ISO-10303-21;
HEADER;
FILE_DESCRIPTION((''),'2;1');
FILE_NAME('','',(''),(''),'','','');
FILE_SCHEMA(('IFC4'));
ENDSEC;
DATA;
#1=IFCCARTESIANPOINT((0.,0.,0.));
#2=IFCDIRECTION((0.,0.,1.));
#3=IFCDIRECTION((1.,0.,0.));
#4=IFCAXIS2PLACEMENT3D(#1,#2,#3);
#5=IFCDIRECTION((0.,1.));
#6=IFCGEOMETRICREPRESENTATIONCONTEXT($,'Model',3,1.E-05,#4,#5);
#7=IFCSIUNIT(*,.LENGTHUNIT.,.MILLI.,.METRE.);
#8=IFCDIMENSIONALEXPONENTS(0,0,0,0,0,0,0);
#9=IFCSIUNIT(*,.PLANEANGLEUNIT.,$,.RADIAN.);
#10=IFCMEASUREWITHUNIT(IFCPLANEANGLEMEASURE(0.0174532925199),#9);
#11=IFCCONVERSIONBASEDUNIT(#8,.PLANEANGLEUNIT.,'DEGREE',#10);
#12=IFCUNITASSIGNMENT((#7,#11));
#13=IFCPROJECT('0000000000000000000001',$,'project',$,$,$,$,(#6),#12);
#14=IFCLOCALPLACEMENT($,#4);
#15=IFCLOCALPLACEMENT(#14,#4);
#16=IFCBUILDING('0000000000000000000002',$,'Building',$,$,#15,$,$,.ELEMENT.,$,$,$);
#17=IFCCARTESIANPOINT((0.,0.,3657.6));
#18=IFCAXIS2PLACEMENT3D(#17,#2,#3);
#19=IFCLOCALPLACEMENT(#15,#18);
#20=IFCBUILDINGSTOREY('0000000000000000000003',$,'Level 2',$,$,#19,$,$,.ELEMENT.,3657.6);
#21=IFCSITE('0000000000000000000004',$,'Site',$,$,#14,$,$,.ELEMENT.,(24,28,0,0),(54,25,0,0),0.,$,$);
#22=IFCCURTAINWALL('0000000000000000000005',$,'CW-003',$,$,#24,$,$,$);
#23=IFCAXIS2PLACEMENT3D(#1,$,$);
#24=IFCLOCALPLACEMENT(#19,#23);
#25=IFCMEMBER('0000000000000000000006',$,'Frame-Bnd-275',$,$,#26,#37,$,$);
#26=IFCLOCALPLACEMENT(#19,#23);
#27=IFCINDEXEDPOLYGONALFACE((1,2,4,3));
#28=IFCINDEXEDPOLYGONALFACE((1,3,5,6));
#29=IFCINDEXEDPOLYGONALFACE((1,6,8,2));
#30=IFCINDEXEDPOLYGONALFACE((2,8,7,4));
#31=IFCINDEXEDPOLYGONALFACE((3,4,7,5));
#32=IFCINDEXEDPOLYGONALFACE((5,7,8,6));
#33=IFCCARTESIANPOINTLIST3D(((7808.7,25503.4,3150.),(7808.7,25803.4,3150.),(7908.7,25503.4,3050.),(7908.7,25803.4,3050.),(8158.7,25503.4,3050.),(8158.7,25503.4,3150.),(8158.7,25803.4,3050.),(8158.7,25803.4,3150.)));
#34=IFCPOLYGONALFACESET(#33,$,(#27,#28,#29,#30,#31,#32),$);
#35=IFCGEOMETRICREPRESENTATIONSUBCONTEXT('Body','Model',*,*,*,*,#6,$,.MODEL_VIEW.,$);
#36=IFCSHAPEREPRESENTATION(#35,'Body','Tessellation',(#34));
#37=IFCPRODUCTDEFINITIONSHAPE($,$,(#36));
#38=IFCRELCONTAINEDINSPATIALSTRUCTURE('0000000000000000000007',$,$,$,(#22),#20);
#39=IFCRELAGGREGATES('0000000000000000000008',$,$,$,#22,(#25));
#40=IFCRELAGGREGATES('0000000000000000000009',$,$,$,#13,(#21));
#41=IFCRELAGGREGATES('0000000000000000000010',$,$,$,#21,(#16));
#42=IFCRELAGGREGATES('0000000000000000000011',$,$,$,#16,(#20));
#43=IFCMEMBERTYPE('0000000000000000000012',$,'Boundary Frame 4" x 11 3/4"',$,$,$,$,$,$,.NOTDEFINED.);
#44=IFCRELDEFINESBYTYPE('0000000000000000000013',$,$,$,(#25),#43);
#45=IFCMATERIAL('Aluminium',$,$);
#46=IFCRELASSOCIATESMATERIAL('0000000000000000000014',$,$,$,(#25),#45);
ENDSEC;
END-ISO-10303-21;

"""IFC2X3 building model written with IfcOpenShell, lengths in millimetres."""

from ifc_helpers import new_model, entity, si_unit, converted_unit, direction, frame, origin_with_axes, place, context, subcontext, project, spatial, polyline, outline, extrude, clip, halfspace, material, type_object, element, aggregate, save


model = new_model("IFC2X3")

# Units and contexts
model_context = context("Model", 3, precision=1e-05, world=origin_with_axes(), true_north=direction((0.0, 1.0)))
body_context = subcontext(model_context, "Body", "Model", "MODEL_VIEW")
ifc_project = project(units=[si_unit("LENGTHUNIT", "METRE", prefix="MILLI"), converted_unit("PLANEANGLEUNIT", "DEGREE", entity("IfcPlaneAngleMeasure", 0.0174532925199), si_unit("PLANEANGLEUNIT", "RADIAN"), dimensions=[0, 0, 0, 0, 0, 0, 0])], contexts=[model_context])

# Site, building, storey
site_placement = place(None, origin_with_axes())
site = spatial("IfcSite", under=ifc_project, at=site_placement, Name="Site", CompositionType="ELEMENT", RefLatitude=(24, 28, 0, 0), RefLongitude=(54, 25, 0, 0), RefElevation=0.0)
building_placement = place(site_placement, origin_with_axes())
building = spatial("IfcBuilding", under=site, at=building_placement, Name="Building", CompositionType="ELEMENT")
storey_placement = place(building_placement, frame((0.0, 0.0, 3657.6), z_axis=(0.0, 0.0, 1.0), x_axis=(1.0, 0.0, 0.0)))
storey = spatial("IfcBuildingStorey", under=building, at=storey_placement, Name="Level 2", CompositionType="ELEMENT", Elevation=3657.6)

# Curtain wall, member
curtain_wall_placement = place(storey_placement, frame((8008.7, 25753.4, 0.0), z_axis=(0.0, 0.0, 1.0), x_axis=(1.0, 0.0, 0.0)))
curtain_wall = element("IfcCurtainWall", 1, at=curtain_wall_placement, inside=storey, Name="CW-003")
ifc_material_1 = material(Name="Aluminium")
member_type_1 = type_object("IfcMemberType", Name="Boundary Frame 4\" x 11 3/4\"", PredefinedType="NOTDEFINED")
member_1_placement = place(curtain_wall_placement, frame((-150.0, 0.0, 3100.0), z_axis=(1.0, 0.0, 0.0), x_axis=(0.0, 0.0, 1.0)))
member_1 = element("IfcMember", 2, at=member_1_placement, type_object=member_type_1, material=ifc_material_1, Name="Frame-Bnd-275", context=body_context, shape_type="Clipping", body=[
    clip(extrude(outline(polyline([(250.0, -50.0), (250.0, 50.0), (-50.0, 50.0), (-50.0, -50.0), (250.0, -50.0)])), frame((0.0, 0.0, -50.0), z_axis=(0.0, 0.0, 1.0), x_axis=(0.0, 1.0, 0.0)), (0.0, 0.0, 1.0), 350.0), halfspace(frame((0.0, 0.0, 0.0), z_axis=(0.707107, 0.0, 0.707107), x_axis=(0.0, -1.0, 0.0)), True)),
])
aggregate(curtain_wall, [member_1])

save(model, "model.ifc")
